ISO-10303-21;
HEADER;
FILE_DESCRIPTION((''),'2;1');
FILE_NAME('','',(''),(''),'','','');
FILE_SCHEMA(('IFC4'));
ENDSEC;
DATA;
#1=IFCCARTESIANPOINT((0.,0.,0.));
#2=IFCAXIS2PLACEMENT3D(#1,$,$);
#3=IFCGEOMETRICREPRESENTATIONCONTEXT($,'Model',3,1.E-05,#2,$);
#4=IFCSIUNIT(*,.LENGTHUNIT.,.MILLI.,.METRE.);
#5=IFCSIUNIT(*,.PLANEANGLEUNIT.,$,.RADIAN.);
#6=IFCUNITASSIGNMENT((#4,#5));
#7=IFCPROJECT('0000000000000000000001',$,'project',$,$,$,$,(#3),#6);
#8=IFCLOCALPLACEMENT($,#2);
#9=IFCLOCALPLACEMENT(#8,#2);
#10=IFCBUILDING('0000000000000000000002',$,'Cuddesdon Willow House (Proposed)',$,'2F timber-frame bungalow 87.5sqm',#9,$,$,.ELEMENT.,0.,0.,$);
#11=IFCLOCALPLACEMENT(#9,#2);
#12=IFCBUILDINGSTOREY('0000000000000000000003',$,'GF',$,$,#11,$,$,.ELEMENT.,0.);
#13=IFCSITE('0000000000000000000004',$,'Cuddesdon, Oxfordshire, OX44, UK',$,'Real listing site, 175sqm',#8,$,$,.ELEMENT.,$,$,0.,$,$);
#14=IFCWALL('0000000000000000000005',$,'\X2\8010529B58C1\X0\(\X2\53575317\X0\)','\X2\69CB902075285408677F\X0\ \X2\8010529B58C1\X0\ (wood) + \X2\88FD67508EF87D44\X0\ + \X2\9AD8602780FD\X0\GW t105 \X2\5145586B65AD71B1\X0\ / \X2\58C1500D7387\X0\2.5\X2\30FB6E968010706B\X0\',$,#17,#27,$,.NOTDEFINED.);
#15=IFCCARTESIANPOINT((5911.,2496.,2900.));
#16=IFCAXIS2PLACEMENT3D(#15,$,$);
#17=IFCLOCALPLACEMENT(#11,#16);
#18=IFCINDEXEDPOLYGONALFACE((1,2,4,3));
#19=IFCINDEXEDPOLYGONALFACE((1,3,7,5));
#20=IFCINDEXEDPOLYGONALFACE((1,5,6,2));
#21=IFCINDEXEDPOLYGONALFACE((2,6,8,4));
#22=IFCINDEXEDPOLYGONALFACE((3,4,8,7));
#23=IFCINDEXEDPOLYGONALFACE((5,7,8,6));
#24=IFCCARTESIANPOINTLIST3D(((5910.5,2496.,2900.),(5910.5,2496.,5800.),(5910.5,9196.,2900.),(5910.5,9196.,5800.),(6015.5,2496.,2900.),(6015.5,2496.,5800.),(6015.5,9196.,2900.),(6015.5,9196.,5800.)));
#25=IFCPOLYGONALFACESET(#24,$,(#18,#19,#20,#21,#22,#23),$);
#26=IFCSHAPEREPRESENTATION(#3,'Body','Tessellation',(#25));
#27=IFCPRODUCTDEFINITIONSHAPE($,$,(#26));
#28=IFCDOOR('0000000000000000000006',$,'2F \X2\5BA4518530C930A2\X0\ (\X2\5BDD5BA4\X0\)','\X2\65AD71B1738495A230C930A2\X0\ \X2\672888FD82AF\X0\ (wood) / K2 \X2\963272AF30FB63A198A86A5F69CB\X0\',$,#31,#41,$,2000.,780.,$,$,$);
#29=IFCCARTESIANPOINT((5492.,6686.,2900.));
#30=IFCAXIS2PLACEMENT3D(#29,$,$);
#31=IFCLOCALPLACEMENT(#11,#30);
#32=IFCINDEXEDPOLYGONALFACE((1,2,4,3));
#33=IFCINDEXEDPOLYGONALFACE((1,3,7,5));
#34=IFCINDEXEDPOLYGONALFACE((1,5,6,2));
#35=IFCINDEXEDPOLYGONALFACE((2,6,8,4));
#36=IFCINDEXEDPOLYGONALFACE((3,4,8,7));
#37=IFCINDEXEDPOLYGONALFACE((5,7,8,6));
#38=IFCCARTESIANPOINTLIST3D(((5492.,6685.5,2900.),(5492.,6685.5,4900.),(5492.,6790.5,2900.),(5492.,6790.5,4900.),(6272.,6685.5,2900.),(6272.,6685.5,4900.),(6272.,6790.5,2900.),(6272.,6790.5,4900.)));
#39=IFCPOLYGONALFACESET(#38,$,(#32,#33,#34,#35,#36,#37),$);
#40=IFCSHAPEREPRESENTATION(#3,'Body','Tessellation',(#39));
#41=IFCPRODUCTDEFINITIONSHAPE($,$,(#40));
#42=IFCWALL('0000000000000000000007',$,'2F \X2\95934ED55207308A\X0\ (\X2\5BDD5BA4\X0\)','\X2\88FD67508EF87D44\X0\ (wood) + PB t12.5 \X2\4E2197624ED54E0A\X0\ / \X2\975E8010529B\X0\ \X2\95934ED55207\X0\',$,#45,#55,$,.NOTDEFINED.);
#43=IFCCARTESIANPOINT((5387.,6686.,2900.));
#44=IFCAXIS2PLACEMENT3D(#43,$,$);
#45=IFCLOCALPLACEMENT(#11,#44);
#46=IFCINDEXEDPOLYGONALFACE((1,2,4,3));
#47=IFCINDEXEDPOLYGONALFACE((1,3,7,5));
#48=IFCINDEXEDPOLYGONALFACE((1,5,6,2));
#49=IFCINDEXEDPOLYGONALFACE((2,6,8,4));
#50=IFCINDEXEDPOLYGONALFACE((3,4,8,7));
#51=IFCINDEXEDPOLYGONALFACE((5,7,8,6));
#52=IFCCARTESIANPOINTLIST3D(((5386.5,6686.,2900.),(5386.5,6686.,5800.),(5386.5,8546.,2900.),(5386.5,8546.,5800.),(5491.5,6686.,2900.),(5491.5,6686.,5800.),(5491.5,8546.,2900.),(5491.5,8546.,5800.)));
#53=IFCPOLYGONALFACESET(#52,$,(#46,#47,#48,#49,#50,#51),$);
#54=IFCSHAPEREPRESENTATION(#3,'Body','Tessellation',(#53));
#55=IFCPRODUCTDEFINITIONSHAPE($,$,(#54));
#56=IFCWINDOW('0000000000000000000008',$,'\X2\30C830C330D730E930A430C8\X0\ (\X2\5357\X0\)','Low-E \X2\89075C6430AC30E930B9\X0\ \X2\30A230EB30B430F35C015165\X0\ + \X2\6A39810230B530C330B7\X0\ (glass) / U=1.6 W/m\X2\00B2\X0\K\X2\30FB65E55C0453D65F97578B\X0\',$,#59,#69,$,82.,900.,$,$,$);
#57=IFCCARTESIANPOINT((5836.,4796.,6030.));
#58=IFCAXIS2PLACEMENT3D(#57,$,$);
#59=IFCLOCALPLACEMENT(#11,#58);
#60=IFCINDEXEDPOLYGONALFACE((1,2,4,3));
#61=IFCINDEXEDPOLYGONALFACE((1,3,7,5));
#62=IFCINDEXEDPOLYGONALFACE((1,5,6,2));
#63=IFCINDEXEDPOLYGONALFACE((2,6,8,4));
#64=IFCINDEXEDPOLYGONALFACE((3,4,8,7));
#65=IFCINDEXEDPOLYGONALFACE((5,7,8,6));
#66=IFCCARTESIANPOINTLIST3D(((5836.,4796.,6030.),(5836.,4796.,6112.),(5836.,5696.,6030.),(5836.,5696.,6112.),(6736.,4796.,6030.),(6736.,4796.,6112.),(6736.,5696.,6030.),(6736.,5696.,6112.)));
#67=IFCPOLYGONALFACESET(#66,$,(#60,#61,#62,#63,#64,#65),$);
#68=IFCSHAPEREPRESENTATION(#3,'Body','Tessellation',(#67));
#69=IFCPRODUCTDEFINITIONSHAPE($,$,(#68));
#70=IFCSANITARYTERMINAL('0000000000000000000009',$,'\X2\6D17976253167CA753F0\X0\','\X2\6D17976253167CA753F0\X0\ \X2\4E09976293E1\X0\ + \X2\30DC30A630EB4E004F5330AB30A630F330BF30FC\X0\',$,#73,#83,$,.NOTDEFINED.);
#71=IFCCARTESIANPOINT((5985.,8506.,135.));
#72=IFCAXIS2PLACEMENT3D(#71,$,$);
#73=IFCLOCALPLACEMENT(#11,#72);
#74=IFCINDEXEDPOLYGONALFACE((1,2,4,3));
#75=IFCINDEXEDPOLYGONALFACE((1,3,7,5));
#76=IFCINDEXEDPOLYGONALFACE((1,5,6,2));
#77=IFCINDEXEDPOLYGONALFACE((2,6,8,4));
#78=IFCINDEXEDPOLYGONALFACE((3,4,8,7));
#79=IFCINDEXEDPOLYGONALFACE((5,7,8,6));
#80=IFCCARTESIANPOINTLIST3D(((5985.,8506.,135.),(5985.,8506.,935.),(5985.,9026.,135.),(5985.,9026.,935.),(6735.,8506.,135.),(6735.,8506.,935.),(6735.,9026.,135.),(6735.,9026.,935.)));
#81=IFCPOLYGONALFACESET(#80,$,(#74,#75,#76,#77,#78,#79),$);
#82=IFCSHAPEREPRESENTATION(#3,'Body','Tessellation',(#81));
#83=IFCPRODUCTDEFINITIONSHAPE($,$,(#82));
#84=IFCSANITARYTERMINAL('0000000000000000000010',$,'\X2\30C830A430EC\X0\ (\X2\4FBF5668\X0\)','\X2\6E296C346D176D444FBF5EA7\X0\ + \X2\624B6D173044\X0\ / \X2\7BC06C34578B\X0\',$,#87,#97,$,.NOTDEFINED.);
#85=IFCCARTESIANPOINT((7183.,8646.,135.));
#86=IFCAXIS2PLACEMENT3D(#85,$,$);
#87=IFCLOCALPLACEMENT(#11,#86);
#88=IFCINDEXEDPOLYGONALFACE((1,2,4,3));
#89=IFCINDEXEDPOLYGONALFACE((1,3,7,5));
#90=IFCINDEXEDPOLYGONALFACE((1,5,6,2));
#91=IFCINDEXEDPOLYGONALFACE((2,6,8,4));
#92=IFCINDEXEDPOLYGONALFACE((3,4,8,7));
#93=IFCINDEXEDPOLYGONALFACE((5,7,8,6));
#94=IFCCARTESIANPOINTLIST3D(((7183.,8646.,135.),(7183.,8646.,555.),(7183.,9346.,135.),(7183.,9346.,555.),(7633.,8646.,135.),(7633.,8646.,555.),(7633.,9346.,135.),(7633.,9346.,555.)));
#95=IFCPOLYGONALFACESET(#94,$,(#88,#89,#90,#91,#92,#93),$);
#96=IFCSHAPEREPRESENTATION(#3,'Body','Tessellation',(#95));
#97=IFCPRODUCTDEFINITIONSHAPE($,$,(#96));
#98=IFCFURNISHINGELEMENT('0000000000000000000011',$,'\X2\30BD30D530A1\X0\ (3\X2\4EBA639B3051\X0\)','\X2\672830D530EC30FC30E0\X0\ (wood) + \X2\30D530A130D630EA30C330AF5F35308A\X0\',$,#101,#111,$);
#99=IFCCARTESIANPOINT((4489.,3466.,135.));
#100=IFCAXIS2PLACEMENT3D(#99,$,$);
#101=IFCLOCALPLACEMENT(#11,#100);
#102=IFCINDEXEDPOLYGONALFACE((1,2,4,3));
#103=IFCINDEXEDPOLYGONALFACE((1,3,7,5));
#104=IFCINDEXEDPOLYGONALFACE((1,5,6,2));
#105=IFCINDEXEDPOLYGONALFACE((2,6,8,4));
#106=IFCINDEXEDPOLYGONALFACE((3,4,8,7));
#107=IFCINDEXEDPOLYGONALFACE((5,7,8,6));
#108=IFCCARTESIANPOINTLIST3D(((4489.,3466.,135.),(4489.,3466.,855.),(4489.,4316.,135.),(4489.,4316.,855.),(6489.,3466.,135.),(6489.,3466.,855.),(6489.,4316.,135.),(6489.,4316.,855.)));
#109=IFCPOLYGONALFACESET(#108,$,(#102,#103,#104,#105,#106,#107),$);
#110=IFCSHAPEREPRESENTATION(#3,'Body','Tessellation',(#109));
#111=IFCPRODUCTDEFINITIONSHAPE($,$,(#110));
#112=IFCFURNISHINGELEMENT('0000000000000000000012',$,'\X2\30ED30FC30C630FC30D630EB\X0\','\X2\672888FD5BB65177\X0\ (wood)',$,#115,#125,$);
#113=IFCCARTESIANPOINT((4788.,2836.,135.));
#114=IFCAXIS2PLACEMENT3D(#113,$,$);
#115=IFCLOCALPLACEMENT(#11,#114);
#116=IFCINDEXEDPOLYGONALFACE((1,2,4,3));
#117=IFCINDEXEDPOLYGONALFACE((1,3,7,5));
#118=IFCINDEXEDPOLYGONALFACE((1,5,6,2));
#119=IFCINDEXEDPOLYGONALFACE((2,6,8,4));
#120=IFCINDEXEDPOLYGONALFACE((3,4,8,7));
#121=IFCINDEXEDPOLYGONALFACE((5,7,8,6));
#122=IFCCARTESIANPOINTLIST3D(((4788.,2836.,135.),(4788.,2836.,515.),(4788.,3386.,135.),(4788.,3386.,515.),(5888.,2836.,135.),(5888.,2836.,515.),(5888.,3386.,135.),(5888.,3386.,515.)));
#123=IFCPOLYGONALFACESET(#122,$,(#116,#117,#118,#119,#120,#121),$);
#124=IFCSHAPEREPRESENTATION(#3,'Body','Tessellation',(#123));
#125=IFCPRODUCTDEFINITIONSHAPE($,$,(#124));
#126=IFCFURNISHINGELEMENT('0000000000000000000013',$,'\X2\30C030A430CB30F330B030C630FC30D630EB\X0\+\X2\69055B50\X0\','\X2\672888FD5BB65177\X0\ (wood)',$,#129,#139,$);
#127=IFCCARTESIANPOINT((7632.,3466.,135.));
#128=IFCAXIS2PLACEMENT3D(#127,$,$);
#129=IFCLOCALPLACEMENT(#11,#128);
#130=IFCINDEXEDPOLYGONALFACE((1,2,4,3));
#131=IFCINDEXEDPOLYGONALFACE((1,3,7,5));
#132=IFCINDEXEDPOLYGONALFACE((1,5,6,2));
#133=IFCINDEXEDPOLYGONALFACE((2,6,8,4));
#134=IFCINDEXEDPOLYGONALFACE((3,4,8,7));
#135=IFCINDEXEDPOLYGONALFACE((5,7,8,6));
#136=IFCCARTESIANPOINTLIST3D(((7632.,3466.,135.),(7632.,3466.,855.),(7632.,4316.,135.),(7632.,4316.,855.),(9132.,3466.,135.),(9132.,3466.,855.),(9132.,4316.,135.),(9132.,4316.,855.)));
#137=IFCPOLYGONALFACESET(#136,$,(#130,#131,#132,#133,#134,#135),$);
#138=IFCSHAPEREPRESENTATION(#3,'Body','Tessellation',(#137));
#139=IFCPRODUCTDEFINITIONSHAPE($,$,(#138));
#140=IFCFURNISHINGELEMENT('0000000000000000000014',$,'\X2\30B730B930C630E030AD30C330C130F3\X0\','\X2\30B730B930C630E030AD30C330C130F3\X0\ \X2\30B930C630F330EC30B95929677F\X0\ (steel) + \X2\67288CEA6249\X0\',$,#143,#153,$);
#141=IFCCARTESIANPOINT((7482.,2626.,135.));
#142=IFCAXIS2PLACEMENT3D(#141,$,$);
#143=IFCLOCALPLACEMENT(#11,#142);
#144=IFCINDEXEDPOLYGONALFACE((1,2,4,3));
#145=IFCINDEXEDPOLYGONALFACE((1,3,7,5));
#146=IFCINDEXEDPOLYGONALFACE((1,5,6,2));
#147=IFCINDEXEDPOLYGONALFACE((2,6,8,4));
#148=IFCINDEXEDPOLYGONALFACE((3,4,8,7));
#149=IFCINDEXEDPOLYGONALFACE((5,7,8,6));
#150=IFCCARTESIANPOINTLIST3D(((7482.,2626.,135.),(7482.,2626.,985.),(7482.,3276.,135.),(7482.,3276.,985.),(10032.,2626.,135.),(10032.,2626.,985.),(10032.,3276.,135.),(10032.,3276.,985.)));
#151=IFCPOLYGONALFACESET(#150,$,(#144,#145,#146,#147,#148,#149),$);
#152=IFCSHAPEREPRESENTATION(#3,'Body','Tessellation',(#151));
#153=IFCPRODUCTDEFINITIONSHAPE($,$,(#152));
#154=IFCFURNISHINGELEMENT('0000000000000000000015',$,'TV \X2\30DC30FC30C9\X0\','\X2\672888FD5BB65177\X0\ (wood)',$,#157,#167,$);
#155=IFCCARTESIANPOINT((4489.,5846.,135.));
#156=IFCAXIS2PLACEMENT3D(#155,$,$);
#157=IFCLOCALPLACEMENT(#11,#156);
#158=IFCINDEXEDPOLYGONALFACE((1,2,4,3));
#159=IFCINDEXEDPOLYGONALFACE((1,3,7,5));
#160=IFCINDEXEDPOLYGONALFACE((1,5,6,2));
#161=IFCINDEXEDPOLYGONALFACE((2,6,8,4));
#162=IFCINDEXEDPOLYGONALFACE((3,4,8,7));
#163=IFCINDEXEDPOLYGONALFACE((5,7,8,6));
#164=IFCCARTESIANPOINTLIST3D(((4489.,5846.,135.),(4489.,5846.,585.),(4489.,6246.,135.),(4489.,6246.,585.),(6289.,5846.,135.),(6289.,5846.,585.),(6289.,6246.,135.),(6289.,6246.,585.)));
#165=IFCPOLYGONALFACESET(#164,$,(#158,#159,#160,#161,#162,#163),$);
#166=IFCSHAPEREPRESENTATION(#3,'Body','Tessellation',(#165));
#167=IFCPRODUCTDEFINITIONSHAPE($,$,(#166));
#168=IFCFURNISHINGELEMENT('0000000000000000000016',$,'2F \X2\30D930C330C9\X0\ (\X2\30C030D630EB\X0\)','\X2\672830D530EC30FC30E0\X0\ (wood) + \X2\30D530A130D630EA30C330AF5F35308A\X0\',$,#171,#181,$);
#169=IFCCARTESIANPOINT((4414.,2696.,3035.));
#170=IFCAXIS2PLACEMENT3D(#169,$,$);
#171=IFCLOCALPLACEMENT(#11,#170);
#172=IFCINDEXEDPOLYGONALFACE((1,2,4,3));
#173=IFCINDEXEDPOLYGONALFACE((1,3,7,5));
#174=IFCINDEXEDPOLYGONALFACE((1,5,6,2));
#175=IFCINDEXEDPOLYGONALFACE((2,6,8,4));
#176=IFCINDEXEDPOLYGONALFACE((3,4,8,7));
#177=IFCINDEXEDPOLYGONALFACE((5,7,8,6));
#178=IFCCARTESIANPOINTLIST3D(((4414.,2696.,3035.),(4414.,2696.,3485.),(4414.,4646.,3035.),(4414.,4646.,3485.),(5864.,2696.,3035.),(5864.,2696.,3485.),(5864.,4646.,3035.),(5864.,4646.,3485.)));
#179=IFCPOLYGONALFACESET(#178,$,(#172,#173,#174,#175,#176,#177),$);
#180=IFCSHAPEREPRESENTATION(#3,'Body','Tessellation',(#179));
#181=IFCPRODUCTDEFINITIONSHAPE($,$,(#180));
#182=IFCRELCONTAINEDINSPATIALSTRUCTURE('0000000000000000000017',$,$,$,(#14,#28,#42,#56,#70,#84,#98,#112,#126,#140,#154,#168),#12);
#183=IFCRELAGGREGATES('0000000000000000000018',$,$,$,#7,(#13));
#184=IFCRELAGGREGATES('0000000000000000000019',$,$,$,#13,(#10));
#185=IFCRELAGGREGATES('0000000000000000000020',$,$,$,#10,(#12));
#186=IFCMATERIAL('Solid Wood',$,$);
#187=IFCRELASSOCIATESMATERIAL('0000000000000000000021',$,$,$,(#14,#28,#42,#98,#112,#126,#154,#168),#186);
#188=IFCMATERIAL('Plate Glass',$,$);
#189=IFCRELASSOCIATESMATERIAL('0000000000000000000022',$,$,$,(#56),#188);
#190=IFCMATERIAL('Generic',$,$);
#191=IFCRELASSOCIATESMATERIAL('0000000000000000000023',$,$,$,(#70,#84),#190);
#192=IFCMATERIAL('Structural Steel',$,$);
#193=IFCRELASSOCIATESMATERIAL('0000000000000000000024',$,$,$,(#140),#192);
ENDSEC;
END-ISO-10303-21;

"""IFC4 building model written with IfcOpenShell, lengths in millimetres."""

from ifc_helpers import new_model, si_unit, frame, frame_2d, origin, place, context, project, spatial, rectangle, extrude, material, element, fill, save


model = new_model("IFC4")

# Units and contexts
model_context = context("Model", 3, precision=1e-05, world=origin())
ifc_project = project(units=[si_unit("LENGTHUNIT", "METRE", prefix="MILLI"), si_unit("PLANEANGLEUNIT", "RADIAN")], contexts=[model_context])

# Site, building, storey
site_placement = place(None, origin())
site = spatial("IfcSite", under=ifc_project, at=site_placement, Name="Cuddesdon, Oxfordshire, OX44, UK", ObjectType="Real listing site, 175sqm", CompositionType="ELEMENT", RefElevation=0.0)
building_placement = place(site_placement, origin())
building = spatial("IfcBuilding", under=site, at=building_placement, Name="Cuddesdon Willow House (Proposed)", ObjectType="2F timber-frame bungalow 87.5sqm", CompositionType="ELEMENT", ElevationOfRefHeight=0.0, ElevationOfTerrain=0.0)
storey_placement = place(building_placement, origin())
storey = spatial("IfcBuildingStorey", under=building, at=storey_placement, Name="GF", CompositionType="ELEMENT", Elevation=0.0)

# Shared definitions
ifc_material_1 = material(Name="Solid Wood")

# Wall, opening, door
wall_1_placement = place(storey_placement, frame((5911.0, 2496.0, 2900.0)))
wall_1 = element("IfcWall", 1, at=wall_1_placement, inside=storey, material=ifc_material_1, Name="耐力壁(南北)", Description="構造用合板 耐力壁 (wood) + 製材軸組 + 高性能GW t105 充填断熱 / 壁倍率2.5・準耐火", PredefinedType="NOTDEFINED", context=model_context, shape_type="SweptSolid", body=[
    extrude(rectangle(XDim=105.0, YDim=6700.0, at=frame_2d((52.0, 3350.0))), frame((5911.0, 2496.0, 2900.0)), (0.0, 0.0, 1.0), 2900.0),
])
opening_1_placement = place(storey_placement, frame((5492.0, 6686.0, 2900.0)))
opening_1 = element("IfcOpeningElement", 2, at=opening_1_placement, cuts=wall_1, PredefinedType="NOTDEFINED", context=model_context, shape_type="SweptSolid", body=[
    extrude(rectangle(XDim=780.0, YDim=105.0, at=frame_2d((390.0, 52.0))), frame((5492.0, 6686.0, 2900.0)), (0.0, 0.0, 1.0), 2000.0),
])
door_1_placement = place(storey_placement, frame((5492.0, 6686.0, 2900.0)))
door_1 = element("IfcDoor", 3, at=door_1_placement, inside=storey, material=ifc_material_1, Name="2F 室内ドア (寝室)", Description="断熱玄関ドア 木製芯 (wood) / K2 防犯・採風機構", OverallHeight=2000.0, OverallWidth=780.0, context=model_context, shape_type="SweptSolid", body=[
    extrude(rectangle(XDim=780.0, YDim=105.0, at=frame_2d((390.0, 52.0))), frame((5492.0, 6686.0, 2900.0)), (0.0, 0.0, 1.0), 2000.0),
])
fill(opening_1, door_1)

# Wall
wall_2_placement = place(storey_placement, frame((5387.0, 6686.0, 2900.0)))
element("IfcWall", 4, at=wall_2_placement, inside=storey, material=ifc_material_1, Name="2F 間仕切り (寝室)", Description="製材軸組 (wood) + PB t12.5 両面仕上 / 非耐力 間仕切", PredefinedType="NOTDEFINED", context=model_context, shape_type="SweptSolid", body=[
    extrude(rectangle(XDim=105.0, YDim=1860.0, at=frame_2d((52.0, 930.0))), frame((5387.0, 6686.0, 2900.0)), (0.0, 0.0, 1.0), 2900.0),
])

# Window
ifc_material_2 = material(Name="Plate Glass")
window_placement = place(storey_placement, frame((5836.0, 4796.0, 6030.0)))
element("IfcWindow", 5, at=window_placement, inside=storey, material=ifc_material_2, Name="トップライト (南)", Description="Low-E 複層ガラス アルゴン封入 + 樹脂サッシ (glass) / U=1.6 W/m²K・日射取得型", OverallHeight=82.0, OverallWidth=900.0, context=model_context, shape_type="SweptSolid", body=[
    extrude(rectangle(XDim=900.0, YDim=900.0, at=frame_2d((450.0, 450.0))), frame((5836.0, 4796.0, 6030.0)), (0.0, 0.0, 1.0), 82.0),
])

# Sanitary terminals
ifc_material_3 = material(Name="Generic")
sanitary_terminal_1_placement = place(storey_placement, frame((5985.0, 8506.0, 135.0)))
element("IfcSanitaryTerminal", 6, at=sanitary_terminal_1_placement, inside=storey, material=ifc_material_3, Name="洗面化粧台", Description="洗面化粧台 三面鏡 + ボウル一体カウンター", PredefinedType="NOTDEFINED", context=model_context, shape_type="SweptSolid", body=[
    extrude(rectangle(XDim=750.0, YDim=520.0, at=frame_2d((375.0, 260.0))), frame((5985.0, 8506.0, 135.0)), (0.0, 0.0, 1.0), 800.0),
])
sanitary_terminal_2_placement = place(storey_placement, frame((7183.0, 8646.0, 135.0)))
element("IfcSanitaryTerminal", 7, at=sanitary_terminal_2_placement, inside=storey, material=ifc_material_3, Name="トイレ (便器)", Description="温水洗浄便座 + 手洗い / 節水型", PredefinedType="NOTDEFINED", context=model_context, shape_type="SweptSolid", body=[
    extrude(rectangle(XDim=450.0, YDim=700.0, at=frame_2d((225.0, 350.0))), frame((7183.0, 8646.0, 135.0)), (0.0, 0.0, 1.0), 420.0),
])

# Furnishing elements
furnishing_1_placement = place(storey_placement, frame((4489.0, 3466.0, 135.0)))
element("IfcFurnishingElement", 8, at=furnishing_1_placement, inside=storey, material=ifc_material_1, Name="ソファ (3人掛け)", Description="木フレーム (wood) + ファブリック張り", context=model_context, shape_type="SweptSolid", body=[
    extrude(rectangle(XDim=2000.0, YDim=850.0, at=frame_2d((1000.0, 425.0))), frame((4489.0, 3466.0, 135.0)), (0.0, 0.0, 1.0), 720.0),
])
furnishing_2_placement = place(storey_placement, frame((4788.0, 2836.0, 135.0)))
element("IfcFurnishingElement", 9, at=furnishing_2_placement, inside=storey, material=ifc_material_1, Name="ローテーブル", Description="木製家具 (wood)", context=model_context, shape_type="SweptSolid", body=[
    extrude(rectangle(XDim=1100.0, YDim=550.0, at=frame_2d((550.0, 275.0))), frame((4788.0, 2836.0, 135.0)), (0.0, 0.0, 1.0), 380.0),
])
furnishing_3_placement = place(storey_placement, frame((7632.0, 3466.0, 135.0)))
element("IfcFurnishingElement", 10, at=furnishing_3_placement, inside=storey, material=ifc_material_1, Name="ダイニングテーブル+椅子", Description="木製家具 (wood)", context=model_context, shape_type="SweptSolid", body=[
    extrude(rectangle(XDim=1500.0, YDim=850.0, at=frame_2d((750.0, 425.0))), frame((7632.0, 3466.0, 135.0)), (0.0, 0.0, 1.0), 720.0),
])
ifc_material_4 = material(Name="Structural Steel")
furnishing_4_placement = place(storey_placement, frame((7482.0, 2626.0, 135.0)))
element("IfcFurnishingElement", 11, at=furnishing_4_placement, inside=storey, material=ifc_material_4, Name="システムキッチン", Description="システムキッチン ステンレス天板 (steel) + 木質扉", context=model_context, shape_type="SweptSolid", body=[
    extrude(rectangle(XDim=2550.0, YDim=650.0, at=frame_2d((1275.0, 325.0))), frame((7482.0, 2626.0, 135.0)), (0.0, 0.0, 1.0), 850.0),
])
furnishing_5_placement = place(storey_placement, frame((4489.0, 5846.0, 135.0)))
element("IfcFurnishingElement", 12, at=furnishing_5_placement, inside=storey, material=ifc_material_1, Name="TV ボード", Description="木製家具 (wood)", context=model_context, shape_type="SweptSolid", body=[
    extrude(rectangle(XDim=1800.0, YDim=400.0, at=frame_2d((900.0, 200.0))), frame((4489.0, 5846.0, 135.0)), (0.0, 0.0, 1.0), 450.0),
])
furnishing_6_placement = place(storey_placement, frame((4414.0, 2696.0, 3035.0)))
element("IfcFurnishingElement", 13, at=furnishing_6_placement, inside=storey, material=ifc_material_1, Name="2F ベッド (ダブル)", Description="木フレーム (wood) + ファブリック張り", context=model_context, shape_type="SweptSolid", body=[
    extrude(rectangle(XDim=1450.0, YDim=1950.0, at=frame_2d((725.0, 975.0))), frame((4414.0, 2696.0, 3035.0)), (0.0, 0.0, 1.0), 450.0),
])

save(model, "model.ifc")
